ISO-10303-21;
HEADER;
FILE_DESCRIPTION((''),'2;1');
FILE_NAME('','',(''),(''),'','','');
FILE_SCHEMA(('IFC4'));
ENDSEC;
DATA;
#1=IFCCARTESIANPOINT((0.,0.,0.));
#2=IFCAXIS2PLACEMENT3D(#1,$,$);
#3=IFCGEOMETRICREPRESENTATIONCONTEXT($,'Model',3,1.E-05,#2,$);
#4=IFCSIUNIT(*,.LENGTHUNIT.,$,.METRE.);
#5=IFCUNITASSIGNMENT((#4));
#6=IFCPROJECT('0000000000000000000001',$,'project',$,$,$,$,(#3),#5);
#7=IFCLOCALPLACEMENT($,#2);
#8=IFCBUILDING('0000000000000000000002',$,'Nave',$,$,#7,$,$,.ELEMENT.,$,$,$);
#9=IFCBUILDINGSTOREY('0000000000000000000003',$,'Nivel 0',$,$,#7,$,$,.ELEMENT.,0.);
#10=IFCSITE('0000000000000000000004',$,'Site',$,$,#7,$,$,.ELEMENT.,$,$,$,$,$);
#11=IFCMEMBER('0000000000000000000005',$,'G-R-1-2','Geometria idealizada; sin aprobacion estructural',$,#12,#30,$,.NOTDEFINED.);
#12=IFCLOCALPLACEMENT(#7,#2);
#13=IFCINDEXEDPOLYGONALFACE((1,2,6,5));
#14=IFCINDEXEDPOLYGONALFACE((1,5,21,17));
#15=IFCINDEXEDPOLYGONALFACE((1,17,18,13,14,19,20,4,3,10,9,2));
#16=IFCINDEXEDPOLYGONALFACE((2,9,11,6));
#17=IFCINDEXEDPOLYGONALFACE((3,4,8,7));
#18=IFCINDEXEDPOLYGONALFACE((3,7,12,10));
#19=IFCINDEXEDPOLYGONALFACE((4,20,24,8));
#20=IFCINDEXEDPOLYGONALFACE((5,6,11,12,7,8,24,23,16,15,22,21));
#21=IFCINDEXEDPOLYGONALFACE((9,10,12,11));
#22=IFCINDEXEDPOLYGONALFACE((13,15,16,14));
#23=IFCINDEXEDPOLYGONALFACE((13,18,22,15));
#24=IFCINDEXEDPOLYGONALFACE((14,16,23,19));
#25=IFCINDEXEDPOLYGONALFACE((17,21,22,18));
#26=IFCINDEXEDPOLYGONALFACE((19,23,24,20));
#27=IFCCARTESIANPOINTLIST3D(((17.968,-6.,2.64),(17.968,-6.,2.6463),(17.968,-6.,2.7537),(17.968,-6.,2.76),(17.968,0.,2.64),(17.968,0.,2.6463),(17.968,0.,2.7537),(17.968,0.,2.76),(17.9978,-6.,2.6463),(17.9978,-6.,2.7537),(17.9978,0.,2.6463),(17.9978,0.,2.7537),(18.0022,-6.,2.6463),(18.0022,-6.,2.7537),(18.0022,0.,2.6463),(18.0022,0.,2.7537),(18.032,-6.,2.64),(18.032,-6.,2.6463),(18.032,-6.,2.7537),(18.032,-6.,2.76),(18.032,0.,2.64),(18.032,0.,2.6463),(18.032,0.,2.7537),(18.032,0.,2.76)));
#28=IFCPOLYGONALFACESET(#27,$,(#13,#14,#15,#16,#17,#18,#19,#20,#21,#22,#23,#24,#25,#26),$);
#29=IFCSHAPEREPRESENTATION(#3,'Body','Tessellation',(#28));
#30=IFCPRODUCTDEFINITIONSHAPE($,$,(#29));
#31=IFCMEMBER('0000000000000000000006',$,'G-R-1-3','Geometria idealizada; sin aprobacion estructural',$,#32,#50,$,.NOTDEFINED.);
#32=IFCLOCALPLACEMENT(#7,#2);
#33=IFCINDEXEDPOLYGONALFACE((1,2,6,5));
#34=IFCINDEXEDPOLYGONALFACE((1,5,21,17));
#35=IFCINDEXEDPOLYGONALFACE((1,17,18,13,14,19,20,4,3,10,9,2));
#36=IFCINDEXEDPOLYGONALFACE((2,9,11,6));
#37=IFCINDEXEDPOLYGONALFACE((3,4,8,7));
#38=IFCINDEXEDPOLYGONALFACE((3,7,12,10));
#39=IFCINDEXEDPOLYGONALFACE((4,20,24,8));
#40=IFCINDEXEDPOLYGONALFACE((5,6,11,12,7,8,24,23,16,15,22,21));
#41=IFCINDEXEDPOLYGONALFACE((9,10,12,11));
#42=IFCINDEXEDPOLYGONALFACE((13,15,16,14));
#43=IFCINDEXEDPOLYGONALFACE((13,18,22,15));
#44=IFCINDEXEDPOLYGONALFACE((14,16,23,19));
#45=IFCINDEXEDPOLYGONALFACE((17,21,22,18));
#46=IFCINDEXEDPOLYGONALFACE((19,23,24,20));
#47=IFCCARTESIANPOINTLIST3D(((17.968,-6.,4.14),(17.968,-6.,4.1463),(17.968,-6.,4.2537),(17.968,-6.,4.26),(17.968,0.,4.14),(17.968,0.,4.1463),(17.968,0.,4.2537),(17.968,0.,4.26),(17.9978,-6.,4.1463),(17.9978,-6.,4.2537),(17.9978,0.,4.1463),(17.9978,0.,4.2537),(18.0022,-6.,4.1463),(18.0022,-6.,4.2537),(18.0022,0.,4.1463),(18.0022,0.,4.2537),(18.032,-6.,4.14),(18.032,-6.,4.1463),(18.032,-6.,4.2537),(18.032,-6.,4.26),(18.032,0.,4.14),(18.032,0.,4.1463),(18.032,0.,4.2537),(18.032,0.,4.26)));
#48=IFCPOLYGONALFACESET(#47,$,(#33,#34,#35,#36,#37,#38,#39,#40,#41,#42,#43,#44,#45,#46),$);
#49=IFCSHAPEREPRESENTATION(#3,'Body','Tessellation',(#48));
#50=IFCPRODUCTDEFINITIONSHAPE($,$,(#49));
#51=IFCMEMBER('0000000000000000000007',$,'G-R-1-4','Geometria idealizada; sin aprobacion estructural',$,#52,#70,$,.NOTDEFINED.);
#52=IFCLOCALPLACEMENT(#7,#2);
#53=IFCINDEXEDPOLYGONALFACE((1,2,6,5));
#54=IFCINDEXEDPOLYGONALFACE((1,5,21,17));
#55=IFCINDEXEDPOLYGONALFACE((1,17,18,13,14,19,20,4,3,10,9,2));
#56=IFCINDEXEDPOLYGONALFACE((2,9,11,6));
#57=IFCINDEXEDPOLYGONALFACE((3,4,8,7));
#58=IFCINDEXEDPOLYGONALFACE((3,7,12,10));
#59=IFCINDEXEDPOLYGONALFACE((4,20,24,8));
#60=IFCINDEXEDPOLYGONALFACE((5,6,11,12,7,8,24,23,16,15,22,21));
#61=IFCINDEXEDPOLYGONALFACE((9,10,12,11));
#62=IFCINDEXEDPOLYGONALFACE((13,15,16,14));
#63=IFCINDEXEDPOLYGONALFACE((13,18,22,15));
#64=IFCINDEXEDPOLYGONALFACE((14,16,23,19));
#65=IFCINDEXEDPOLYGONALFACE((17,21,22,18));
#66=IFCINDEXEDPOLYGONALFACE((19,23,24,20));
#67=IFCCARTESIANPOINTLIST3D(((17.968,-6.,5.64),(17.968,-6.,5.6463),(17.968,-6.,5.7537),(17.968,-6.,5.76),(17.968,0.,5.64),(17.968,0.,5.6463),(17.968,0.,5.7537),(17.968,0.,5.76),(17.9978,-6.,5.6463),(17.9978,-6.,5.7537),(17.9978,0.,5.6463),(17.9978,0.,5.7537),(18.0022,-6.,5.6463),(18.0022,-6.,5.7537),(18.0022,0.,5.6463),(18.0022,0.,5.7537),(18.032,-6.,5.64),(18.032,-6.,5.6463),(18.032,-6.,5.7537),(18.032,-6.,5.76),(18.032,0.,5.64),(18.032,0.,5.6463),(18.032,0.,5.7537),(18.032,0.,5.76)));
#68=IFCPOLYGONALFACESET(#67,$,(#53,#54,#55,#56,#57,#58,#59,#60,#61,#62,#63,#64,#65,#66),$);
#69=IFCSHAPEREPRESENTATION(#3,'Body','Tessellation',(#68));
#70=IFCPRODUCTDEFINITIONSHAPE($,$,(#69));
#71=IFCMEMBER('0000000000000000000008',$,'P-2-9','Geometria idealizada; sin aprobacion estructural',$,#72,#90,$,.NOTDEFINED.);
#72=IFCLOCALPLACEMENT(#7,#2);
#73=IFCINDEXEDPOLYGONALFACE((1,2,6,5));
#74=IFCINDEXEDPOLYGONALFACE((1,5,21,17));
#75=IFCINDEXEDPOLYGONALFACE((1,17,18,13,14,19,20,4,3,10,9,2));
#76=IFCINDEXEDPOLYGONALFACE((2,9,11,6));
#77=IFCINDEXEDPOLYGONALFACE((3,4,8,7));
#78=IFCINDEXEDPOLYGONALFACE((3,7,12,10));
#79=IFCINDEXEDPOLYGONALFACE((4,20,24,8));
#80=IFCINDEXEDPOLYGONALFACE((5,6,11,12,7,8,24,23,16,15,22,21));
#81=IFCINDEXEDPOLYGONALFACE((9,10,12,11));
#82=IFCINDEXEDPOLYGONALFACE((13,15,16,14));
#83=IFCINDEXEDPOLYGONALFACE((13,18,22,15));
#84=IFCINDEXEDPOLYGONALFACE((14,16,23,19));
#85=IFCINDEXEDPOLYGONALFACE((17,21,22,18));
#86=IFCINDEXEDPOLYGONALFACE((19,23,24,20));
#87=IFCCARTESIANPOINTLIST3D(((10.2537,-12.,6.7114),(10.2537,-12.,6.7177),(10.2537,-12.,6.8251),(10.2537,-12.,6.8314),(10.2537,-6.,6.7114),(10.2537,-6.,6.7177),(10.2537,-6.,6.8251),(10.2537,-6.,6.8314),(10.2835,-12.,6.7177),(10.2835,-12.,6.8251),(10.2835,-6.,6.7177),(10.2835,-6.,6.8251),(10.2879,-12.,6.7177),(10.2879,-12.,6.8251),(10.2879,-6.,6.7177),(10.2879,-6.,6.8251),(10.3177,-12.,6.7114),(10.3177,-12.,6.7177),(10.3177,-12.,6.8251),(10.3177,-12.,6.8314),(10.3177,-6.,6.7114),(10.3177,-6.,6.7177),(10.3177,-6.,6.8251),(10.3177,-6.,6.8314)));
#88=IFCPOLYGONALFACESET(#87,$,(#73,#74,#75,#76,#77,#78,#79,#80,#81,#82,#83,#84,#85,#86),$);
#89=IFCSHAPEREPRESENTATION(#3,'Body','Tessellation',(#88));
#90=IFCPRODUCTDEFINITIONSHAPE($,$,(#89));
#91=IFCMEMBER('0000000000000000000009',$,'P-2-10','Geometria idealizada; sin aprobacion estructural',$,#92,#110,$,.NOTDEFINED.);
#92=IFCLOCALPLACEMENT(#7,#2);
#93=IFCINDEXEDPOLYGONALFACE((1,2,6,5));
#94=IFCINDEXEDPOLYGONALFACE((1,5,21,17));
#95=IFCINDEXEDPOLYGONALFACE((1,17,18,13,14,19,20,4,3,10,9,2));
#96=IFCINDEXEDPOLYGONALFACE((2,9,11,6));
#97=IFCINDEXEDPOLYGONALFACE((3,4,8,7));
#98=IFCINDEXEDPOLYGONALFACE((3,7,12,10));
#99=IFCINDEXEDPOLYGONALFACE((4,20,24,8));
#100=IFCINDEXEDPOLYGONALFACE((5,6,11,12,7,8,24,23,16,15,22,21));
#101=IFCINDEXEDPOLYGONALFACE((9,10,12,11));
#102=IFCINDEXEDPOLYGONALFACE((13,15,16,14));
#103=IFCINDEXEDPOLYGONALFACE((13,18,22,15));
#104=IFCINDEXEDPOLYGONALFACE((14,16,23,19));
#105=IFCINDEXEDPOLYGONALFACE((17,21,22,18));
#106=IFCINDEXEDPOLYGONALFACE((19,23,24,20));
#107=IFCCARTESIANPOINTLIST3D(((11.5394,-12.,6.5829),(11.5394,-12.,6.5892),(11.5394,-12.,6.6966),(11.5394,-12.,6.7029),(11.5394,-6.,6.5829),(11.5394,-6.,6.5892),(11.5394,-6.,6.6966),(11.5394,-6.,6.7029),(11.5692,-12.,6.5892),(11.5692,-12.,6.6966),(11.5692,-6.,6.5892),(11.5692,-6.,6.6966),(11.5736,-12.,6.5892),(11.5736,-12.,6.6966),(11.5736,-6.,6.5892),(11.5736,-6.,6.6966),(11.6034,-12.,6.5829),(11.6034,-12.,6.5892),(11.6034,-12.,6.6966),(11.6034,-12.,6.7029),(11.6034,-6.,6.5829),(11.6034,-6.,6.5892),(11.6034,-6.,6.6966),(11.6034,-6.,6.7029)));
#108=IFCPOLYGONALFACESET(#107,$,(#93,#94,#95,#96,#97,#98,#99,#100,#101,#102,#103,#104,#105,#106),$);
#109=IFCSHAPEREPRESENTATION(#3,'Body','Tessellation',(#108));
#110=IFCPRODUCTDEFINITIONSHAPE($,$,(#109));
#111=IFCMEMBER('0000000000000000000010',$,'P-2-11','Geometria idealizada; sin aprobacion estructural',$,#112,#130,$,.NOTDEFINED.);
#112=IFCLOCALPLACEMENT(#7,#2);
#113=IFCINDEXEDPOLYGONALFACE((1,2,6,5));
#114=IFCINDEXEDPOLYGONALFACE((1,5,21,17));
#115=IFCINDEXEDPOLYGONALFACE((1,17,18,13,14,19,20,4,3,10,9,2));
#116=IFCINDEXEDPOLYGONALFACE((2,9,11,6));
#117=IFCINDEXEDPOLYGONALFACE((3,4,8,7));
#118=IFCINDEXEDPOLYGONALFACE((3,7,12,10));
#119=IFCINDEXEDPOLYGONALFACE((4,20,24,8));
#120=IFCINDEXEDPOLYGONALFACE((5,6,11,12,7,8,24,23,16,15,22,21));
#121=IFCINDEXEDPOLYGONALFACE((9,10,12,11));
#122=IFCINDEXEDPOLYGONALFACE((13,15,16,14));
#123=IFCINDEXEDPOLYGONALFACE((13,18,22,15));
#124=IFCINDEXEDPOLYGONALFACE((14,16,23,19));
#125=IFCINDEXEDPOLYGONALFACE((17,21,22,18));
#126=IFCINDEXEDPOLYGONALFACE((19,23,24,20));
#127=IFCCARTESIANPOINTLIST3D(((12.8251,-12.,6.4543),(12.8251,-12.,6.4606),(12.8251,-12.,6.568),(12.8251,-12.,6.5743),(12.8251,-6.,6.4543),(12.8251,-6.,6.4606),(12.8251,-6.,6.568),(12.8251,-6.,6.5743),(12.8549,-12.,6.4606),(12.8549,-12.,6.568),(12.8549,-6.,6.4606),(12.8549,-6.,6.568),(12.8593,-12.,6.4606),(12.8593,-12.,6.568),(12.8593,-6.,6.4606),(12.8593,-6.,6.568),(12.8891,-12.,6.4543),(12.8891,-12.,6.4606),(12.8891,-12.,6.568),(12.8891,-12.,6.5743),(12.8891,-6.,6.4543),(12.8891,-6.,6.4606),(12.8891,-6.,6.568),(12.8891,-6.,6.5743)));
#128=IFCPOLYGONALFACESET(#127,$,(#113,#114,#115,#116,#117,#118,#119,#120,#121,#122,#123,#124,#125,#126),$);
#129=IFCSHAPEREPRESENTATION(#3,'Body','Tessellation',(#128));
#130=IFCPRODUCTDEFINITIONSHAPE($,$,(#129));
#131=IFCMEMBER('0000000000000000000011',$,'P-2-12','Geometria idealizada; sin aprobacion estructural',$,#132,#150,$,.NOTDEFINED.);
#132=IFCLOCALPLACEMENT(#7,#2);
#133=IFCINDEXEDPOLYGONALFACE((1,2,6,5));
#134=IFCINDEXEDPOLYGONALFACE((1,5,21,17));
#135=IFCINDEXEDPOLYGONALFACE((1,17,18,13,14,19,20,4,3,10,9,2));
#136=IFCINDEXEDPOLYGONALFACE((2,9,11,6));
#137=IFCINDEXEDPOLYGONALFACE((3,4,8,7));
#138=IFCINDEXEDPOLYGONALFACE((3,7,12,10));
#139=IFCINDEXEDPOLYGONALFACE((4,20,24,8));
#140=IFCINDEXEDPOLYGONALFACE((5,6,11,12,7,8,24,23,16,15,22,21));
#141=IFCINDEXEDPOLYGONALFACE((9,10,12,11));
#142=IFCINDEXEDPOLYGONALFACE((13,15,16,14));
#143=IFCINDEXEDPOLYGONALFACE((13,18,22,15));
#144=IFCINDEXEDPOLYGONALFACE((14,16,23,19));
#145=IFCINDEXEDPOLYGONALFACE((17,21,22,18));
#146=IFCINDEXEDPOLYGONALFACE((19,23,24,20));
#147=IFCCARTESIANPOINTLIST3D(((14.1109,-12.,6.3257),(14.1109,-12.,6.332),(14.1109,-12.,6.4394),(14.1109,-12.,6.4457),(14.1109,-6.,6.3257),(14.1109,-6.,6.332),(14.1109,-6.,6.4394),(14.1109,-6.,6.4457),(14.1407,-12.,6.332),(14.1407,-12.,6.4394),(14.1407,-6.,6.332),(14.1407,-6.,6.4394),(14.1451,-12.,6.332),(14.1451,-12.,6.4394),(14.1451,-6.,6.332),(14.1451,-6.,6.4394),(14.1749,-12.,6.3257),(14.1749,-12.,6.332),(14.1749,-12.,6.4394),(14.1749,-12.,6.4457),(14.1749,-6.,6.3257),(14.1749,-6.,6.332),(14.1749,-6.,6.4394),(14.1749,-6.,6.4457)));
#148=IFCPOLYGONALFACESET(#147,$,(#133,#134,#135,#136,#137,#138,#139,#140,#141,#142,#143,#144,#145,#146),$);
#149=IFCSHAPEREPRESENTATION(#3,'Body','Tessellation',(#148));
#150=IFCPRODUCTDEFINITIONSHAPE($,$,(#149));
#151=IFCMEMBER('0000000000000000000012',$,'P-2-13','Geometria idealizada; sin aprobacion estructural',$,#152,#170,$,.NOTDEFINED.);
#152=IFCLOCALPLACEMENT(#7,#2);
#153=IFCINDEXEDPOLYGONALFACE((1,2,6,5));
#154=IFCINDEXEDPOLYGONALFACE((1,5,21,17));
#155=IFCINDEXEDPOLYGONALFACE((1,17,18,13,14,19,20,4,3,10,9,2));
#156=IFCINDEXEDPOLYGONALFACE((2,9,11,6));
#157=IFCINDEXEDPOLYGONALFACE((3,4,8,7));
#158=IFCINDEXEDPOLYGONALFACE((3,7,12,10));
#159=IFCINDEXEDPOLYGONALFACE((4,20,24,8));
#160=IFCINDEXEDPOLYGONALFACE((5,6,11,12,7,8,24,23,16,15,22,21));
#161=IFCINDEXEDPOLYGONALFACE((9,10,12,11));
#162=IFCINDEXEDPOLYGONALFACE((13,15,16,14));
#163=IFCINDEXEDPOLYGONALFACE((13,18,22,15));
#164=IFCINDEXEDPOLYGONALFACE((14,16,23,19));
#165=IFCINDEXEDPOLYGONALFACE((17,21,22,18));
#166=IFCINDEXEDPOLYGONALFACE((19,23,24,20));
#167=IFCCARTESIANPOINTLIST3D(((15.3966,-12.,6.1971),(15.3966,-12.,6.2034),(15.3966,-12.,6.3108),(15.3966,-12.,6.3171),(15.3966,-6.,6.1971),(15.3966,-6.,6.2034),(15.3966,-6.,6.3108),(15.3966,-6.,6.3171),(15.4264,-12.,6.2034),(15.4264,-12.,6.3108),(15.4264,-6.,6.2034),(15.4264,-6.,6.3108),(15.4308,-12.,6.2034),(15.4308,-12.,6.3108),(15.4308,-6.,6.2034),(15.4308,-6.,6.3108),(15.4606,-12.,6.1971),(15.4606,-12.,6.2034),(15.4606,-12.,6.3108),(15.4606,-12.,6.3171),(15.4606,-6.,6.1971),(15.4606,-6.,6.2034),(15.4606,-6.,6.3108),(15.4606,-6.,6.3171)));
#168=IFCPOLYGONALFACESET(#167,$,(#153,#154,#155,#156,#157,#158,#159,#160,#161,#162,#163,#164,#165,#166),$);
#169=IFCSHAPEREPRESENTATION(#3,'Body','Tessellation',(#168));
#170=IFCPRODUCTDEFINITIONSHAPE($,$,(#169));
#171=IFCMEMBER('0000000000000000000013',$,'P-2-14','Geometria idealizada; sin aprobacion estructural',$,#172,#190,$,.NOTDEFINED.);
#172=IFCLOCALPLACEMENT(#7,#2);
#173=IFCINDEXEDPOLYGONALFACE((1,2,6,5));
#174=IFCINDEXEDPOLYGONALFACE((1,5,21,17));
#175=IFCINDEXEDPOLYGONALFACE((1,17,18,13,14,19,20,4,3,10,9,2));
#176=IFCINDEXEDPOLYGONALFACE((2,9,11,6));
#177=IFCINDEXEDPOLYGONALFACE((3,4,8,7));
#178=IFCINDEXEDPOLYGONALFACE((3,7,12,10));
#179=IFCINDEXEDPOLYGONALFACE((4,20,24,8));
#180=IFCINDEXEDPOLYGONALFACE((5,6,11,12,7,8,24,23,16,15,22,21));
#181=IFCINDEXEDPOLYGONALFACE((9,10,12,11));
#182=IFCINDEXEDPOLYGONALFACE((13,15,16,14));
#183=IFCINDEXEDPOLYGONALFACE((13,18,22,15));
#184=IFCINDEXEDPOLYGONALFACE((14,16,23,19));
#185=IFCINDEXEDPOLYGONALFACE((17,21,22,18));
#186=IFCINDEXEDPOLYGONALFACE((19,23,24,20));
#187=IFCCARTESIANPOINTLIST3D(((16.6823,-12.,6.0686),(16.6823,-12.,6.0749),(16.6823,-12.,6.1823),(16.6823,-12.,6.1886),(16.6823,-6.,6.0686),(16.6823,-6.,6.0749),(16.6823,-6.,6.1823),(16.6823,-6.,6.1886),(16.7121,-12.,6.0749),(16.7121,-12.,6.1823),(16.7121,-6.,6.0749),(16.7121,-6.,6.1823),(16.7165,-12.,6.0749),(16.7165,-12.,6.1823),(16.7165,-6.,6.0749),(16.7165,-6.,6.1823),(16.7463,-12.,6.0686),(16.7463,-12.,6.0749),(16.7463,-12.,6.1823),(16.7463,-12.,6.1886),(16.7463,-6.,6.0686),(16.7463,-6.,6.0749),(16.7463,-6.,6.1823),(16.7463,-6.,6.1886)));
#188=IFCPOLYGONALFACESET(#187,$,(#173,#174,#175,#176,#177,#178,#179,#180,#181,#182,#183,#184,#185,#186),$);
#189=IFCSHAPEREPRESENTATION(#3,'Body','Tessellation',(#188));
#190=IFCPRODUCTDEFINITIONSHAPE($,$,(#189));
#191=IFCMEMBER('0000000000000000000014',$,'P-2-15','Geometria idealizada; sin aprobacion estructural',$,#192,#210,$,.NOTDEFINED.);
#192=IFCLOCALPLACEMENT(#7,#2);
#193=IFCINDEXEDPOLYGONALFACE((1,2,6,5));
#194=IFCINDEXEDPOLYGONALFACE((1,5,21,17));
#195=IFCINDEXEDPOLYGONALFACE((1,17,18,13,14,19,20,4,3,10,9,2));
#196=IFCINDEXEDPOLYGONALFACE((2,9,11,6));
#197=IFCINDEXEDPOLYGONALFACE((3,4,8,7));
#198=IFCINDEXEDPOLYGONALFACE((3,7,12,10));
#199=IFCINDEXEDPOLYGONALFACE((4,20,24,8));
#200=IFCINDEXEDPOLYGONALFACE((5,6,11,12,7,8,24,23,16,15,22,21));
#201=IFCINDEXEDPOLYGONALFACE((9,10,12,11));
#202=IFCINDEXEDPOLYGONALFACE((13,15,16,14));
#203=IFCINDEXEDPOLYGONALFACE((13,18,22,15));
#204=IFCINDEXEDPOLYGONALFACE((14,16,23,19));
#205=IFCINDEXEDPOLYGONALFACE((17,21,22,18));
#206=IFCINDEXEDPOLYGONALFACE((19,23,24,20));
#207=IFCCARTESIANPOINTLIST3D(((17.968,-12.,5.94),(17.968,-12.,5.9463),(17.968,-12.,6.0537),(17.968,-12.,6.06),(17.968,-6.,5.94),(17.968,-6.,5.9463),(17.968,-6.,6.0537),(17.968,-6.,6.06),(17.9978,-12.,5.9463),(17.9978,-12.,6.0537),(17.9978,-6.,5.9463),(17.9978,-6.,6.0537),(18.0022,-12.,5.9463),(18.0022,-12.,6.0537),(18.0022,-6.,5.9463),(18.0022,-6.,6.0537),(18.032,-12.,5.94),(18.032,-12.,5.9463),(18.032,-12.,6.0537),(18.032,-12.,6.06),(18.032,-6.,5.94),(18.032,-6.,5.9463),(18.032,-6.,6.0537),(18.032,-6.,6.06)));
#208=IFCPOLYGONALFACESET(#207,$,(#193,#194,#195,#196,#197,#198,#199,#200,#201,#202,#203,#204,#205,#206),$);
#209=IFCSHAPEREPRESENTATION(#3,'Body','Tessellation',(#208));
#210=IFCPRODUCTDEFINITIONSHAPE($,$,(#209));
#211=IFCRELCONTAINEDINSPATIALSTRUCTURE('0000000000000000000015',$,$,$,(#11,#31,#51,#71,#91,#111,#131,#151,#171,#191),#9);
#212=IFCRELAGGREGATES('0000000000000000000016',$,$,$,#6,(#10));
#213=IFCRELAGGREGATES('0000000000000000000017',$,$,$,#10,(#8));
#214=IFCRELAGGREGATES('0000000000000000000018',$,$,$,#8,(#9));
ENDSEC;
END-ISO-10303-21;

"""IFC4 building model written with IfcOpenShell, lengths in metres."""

from ifc_helpers import new_model, si_unit, frame, origin, place, context, project, spatial, polyline, outline, extrude, element, save


model = new_model("IFC4")

# Units and contexts
model_context = context("Model", 3, precision=1e-05, world=origin())
ifc_project = project(units=[si_unit("LENGTHUNIT", "METRE")], contexts=[model_context])

# Site, building, storey
placement = place(None, origin())
site = spatial("IfcSite", under=ifc_project, at=placement, Name="Site", CompositionType="ELEMENT")
building = spatial("IfcBuilding", under=site, at=placement, Name="Nave", CompositionType="ELEMENT")
storey = spatial("IfcBuildingStorey", under=building, at=placement, Name="Nivel 0", CompositionType="ELEMENT", Elevation=0.0)

# Members
for number, where, z_axis, x_axis, name in (
    (1, (18.0, 0.0, 2.7), (0.0, -1.0, 0.0), (1.0, 0.0, 0.0), "G-R-1-2"),
    (2, (18.0, 0.0, 4.2), (0.0, -1.0, 0.0), (1.0, 0.0, 0.0), "G-R-1-3"),
    (3, (18.0, 0.0, 5.7), (0.0, -1.0, 0.0), (1.0, 0.0, 0.0), "G-R-1-4"),
    (4, (10.2857, -6.0, 6.7714), (0.0, -1.0, 0.0), (1.0, 0.0, 0.0), "P-2-9"),
    (5, (11.5714, -6.0, 6.6429), (0.0, -1.0, 0.0), (1.0, 0.0, 0.0), "P-2-10"),
    (6, (12.8571, -6.0, 6.5143), (0.0, -1.0, 0.0), (1.0, 0.0, 0.0), "P-2-11"),
    (7, (14.1429, -6.0, 6.3857), (0.0, -1.0, 0.0), (1.0, 0.0, 0.0), "P-2-12"),
    (8, (15.4286, -6.0, 6.2571), (0.0, -1.0, 0.0), (1.0, 0.0, 0.0), "P-2-13"),
    (9, (16.7143, -6.0, 6.1286), (0.0, -1.0, 0.0), (1.0, 0.0, 0.0), "P-2-14"),
    (10, (18.0, -6.0, 6.0), (0.0, -1.0, 0.0), (1.0, 0.0, 0.0), "P-2-15"),
):
    element("IfcMember", number, at=place(placement, frame(where, z_axis=z_axis, x_axis=x_axis)), inside=storey, Name=name, Description="Geometria idealizada; sin aprobacion estructural", PredefinedType="NOTDEFINED", context=model_context, shape_type="SweptSolid", body=[
        extrude(outline(polyline([(-0.032, -0.06), (0.032, -0.06), (0.032, -0.0537), (0.0022, -0.0537), (0.0022, 0.0537), (0.032, 0.0537), (0.032, 0.06), (-0.032, 0.06), (-0.032, 0.0537), (-0.0022, 0.0537), (-0.0022, -0.0537), (-0.032, -0.0537), (-0.032, -0.06)])), origin(), (0.0, 0.0, 1.0), 6.0),
    ])

save(model, "model.ifc")
